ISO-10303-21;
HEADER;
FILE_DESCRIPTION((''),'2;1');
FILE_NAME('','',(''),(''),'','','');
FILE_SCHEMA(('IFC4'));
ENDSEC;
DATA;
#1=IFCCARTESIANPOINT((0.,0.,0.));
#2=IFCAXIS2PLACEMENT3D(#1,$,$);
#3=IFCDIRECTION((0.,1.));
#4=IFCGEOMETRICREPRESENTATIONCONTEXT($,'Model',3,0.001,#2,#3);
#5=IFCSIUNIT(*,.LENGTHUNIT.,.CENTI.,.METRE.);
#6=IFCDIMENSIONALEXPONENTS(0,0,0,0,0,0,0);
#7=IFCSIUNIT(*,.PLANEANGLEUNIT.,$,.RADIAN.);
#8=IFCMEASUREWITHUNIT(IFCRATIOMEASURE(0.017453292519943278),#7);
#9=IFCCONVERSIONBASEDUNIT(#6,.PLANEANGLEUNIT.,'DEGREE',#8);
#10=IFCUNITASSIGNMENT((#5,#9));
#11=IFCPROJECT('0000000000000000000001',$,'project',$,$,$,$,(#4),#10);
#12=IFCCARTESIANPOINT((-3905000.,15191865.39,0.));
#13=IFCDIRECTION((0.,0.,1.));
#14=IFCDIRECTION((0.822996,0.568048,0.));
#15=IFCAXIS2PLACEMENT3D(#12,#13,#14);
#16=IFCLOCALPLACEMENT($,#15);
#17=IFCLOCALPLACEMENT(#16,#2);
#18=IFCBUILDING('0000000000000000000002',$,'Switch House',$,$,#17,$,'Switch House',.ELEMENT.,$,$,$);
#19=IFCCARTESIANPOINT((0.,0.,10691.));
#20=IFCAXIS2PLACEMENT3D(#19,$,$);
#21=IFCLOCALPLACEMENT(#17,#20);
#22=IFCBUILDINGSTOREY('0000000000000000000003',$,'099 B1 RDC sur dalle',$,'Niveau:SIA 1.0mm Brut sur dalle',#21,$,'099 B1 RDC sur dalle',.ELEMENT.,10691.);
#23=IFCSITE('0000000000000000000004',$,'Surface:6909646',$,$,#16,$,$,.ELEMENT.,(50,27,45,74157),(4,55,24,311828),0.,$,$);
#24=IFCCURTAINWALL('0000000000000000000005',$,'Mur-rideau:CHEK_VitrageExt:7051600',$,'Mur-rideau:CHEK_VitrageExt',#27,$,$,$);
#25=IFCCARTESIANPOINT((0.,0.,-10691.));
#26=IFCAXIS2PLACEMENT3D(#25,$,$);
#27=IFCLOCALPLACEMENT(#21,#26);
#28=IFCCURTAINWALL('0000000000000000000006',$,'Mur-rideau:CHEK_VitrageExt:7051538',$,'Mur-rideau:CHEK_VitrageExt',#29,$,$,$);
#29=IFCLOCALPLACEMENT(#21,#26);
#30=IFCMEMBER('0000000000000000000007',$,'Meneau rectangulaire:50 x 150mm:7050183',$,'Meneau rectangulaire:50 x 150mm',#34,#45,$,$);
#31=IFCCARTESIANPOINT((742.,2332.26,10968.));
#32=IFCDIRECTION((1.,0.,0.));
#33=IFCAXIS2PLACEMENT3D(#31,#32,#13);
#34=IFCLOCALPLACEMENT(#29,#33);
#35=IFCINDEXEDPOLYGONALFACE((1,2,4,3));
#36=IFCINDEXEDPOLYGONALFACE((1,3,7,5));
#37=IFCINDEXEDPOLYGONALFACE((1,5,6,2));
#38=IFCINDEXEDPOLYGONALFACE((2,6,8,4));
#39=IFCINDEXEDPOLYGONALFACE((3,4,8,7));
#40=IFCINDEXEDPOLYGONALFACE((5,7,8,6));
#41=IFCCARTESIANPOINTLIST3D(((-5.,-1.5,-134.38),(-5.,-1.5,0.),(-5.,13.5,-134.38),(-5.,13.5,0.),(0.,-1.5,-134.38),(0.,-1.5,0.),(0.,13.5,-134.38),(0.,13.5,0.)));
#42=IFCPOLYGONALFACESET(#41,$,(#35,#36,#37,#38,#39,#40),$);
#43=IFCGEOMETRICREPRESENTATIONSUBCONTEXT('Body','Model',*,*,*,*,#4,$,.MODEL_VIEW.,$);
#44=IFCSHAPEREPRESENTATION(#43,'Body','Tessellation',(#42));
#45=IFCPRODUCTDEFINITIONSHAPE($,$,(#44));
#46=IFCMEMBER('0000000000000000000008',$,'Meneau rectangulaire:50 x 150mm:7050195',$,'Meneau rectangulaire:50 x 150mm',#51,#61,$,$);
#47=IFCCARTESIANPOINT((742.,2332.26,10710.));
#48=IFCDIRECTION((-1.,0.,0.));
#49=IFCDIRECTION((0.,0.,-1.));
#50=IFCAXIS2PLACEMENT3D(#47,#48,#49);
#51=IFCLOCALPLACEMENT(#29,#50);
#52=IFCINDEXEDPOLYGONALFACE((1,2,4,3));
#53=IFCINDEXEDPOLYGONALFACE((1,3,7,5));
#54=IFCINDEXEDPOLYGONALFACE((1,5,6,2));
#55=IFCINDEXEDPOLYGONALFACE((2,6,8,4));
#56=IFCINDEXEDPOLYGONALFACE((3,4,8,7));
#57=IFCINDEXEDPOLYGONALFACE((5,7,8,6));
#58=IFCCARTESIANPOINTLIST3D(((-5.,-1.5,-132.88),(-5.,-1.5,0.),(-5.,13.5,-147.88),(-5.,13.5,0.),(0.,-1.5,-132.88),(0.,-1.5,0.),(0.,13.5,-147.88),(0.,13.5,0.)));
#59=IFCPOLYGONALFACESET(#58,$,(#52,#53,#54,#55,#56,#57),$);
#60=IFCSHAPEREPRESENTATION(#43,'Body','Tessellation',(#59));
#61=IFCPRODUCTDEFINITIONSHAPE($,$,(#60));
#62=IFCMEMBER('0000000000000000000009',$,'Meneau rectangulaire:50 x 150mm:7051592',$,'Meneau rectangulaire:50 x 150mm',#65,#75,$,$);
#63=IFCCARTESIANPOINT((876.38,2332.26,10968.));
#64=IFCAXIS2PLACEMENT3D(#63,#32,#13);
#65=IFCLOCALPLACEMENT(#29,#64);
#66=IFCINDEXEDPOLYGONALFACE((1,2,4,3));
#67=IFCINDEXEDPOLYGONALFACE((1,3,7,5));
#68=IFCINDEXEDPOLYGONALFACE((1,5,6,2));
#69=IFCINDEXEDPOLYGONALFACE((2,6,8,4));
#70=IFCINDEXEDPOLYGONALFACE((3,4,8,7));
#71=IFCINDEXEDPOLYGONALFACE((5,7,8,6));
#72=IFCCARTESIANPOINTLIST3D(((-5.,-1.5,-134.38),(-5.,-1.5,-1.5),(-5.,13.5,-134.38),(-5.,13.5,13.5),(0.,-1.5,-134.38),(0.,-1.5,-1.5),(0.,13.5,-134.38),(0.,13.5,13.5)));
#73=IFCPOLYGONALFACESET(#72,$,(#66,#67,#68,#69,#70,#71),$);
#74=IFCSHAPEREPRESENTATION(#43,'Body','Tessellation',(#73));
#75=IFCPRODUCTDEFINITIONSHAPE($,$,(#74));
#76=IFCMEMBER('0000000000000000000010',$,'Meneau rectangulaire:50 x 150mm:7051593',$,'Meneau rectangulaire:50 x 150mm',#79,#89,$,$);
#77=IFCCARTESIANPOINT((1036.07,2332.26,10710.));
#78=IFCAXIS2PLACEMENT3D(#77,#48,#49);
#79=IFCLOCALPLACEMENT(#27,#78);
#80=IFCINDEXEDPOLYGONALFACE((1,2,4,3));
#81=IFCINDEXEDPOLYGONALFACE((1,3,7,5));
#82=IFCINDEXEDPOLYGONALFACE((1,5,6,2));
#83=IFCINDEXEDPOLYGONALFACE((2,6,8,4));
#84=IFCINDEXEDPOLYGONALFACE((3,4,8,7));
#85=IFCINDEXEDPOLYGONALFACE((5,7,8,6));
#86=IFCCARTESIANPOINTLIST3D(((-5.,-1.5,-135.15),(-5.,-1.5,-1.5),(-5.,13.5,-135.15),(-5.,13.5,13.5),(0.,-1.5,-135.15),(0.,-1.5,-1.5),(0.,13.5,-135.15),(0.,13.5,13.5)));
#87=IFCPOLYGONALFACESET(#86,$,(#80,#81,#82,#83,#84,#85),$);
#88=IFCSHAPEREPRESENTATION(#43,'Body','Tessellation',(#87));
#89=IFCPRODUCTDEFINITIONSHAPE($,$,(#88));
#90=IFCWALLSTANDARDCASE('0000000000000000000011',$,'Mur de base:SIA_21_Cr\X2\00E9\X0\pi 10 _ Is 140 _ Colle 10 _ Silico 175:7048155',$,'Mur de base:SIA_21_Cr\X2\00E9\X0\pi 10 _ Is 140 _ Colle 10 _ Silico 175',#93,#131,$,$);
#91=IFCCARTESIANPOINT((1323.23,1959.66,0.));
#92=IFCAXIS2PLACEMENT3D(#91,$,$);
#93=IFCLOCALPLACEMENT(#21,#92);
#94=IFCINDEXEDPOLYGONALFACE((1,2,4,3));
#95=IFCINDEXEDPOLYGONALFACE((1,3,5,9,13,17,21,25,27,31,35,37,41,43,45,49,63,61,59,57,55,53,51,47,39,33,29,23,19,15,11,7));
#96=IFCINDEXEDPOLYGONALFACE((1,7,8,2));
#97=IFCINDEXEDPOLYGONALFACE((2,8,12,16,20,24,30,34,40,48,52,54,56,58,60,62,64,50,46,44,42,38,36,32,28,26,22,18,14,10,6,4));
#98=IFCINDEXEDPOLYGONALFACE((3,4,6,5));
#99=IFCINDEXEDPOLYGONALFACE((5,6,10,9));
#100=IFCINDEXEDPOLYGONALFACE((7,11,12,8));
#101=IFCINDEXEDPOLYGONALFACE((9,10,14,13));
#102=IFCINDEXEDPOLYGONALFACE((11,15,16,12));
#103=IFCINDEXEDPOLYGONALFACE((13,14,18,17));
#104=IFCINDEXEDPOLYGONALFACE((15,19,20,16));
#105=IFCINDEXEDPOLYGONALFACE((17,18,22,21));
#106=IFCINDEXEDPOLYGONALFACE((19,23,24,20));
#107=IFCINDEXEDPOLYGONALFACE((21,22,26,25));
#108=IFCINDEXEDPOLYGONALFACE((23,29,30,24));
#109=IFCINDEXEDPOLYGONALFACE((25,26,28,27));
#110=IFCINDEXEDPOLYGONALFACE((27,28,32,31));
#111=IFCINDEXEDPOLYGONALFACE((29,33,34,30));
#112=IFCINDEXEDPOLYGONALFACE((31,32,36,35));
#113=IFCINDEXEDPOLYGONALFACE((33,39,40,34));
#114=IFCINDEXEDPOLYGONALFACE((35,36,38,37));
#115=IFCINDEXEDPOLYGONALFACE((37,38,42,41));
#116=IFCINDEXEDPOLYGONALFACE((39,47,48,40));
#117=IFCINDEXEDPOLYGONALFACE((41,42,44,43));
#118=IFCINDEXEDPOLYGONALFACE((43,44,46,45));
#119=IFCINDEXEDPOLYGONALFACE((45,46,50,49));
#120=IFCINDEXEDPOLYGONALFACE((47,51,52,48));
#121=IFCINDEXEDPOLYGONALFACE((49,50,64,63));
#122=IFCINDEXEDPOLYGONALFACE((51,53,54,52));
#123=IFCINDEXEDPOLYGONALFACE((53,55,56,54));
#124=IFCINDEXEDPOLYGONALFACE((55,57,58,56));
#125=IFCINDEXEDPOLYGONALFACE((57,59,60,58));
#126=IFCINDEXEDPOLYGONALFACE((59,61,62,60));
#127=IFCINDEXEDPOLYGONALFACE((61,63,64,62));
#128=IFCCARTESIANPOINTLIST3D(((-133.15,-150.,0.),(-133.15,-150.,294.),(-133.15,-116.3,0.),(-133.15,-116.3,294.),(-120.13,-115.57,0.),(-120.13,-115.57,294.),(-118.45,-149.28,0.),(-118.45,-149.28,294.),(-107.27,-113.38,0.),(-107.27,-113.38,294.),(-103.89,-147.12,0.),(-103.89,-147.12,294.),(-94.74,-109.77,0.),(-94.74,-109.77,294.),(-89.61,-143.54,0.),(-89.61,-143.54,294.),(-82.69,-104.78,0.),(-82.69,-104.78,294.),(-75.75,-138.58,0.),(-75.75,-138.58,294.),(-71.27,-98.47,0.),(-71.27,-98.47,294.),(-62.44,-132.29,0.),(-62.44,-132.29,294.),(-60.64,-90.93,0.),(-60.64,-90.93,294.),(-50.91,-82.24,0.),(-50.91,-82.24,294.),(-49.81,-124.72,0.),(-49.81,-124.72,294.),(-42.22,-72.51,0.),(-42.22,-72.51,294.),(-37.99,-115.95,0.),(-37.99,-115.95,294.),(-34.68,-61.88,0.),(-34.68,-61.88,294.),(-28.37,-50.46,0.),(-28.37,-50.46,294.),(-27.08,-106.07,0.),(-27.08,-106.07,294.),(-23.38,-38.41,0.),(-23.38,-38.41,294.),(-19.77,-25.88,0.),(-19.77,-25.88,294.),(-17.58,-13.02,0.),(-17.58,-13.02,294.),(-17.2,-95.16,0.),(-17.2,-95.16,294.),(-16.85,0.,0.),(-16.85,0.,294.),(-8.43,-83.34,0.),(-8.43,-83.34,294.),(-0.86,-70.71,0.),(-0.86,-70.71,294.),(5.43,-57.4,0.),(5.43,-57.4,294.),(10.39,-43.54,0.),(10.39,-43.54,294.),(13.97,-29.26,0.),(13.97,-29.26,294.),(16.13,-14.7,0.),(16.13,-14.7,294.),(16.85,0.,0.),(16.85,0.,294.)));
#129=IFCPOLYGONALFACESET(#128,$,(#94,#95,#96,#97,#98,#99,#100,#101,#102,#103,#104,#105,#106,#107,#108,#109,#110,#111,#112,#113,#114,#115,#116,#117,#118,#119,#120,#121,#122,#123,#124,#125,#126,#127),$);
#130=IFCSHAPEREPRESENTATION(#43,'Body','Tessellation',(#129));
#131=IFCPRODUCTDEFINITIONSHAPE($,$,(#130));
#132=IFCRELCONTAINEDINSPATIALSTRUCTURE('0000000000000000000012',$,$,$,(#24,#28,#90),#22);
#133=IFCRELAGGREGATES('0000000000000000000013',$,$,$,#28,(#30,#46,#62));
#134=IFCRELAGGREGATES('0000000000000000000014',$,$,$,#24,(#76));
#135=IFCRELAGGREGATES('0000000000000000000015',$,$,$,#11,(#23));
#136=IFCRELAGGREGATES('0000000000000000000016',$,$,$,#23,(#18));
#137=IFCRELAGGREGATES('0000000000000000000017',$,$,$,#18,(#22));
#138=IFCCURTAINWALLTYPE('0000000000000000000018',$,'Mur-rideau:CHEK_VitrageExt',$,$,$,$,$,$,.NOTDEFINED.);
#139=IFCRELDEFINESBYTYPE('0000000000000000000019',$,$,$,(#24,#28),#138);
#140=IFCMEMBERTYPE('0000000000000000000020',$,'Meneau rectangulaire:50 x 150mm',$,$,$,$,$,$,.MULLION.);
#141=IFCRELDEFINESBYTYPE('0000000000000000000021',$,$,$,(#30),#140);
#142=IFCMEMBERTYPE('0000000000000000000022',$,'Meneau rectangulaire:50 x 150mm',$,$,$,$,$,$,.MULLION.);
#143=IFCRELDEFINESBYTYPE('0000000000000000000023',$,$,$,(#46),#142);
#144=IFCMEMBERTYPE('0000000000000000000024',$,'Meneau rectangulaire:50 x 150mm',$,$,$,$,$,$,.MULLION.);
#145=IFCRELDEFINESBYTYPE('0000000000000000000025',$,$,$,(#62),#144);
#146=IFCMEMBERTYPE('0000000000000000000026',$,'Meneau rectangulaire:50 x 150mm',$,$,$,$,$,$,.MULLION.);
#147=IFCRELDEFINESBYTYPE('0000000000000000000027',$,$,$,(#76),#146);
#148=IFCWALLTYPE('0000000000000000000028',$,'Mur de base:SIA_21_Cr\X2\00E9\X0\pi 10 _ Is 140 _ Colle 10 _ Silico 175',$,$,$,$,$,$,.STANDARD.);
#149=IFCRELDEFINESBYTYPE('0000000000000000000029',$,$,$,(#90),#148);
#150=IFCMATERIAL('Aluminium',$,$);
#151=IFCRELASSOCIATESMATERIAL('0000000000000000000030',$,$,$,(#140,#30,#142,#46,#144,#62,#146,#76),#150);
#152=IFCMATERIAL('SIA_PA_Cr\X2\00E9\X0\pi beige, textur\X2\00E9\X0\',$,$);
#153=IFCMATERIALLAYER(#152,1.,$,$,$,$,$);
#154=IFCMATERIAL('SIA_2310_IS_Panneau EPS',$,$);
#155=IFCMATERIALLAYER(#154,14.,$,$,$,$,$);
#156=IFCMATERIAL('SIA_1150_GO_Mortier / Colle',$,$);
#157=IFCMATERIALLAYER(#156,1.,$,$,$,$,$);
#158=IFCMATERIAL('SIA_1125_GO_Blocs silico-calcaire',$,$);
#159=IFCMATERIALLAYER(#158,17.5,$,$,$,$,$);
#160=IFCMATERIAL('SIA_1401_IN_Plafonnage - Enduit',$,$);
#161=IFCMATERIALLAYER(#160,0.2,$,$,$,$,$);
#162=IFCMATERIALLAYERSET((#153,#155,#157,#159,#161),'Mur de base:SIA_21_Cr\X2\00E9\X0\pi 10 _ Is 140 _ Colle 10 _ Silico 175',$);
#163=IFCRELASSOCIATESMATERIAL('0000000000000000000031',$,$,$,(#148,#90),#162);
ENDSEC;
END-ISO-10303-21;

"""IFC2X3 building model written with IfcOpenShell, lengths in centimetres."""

from ifc_helpers import new_model, entity, si_unit, converted_unit, direction, frame, frame_2d, origin, origin_2d_with_axis, place, context, subcontext, project, spatial, polyline, circle_curve, parameter, trimmed, segment, composite_curve, rectangle, outline, extrude, clip, halfspace, source, transform, mapped, material, layer, layer_set, layer_usage, type_object, type_shapes, element, aggregate, save


model = new_model("IFC2X3")

# Units and contexts
model_context = context("Model", 3, precision=0.001, world=origin(), true_north=direction((0.0, 1.0)))
body_context = subcontext(model_context, "Body", "Model", "MODEL_VIEW")
ifc_project = project(units=[si_unit("LENGTHUNIT", "METRE", prefix="CENTI"), converted_unit("PLANEANGLEUNIT", "DEGREE", entity("IfcRatioMeasure", 0.017453292519943278), si_unit("PLANEANGLEUNIT", "RADIAN"), dimensions=[0, 0, 0, 0, 0, 0, 0])], contexts=[model_context])

# Site, building, storey
site_placement = place(None, frame((-3905000.0, 15191865.39, 0.0), z_axis=(0.0, 0.0, 1.0), x_axis=(0.822996, 0.568048, 0.0)))
site = spatial("IfcSite", under=ifc_project, at=site_placement, Name="Surface:6909646", CompositionType="ELEMENT", RefLatitude=(50, 27, 45, 74157), RefLongitude=(4, 55, 24, 311828), RefElevation=0.0)
building_placement = place(site_placement, origin())
building = spatial("IfcBuilding", under=site, at=building_placement, Name="Switch House", LongName="Switch House", CompositionType="ELEMENT")
storey_placement = place(building_placement, frame((0.0, 0.0, 10691.0)))
storey = spatial("IfcBuildingStorey", under=building, at=storey_placement, Name="099 B1 RDC sur dalle", ObjectType="Niveau:SIA 1.0mm Brut sur dalle", LongName="099 B1 RDC sur dalle", CompositionType="ELEMENT", Elevation=10691.0)

# Curtain wall
curtain_wall_type = type_object("IfcCurtainWallType", Name="Mur-rideau:CHEK_VitrageExt", PredefinedType="NOTDEFINED")
ifc_material_1 = material(Name="Aluminium")
curtain_wall_1_placement = place(storey_placement, frame((0.0, 0.0, -10691.0)))
curtain_wall_1 = element("IfcCurtainWall", 1, at=curtain_wall_1_placement, inside=storey, type_object=curtain_wall_type, Name="Mur-rideau:CHEK_VitrageExt:7051600", ObjectType="Mur-rideau:CHEK_VitrageExt")

# Curtain wall
curtain_wall_2_placement = place(storey_placement, frame((0.0, 0.0, -10691.0)))
curtain_wall_2 = element("IfcCurtainWall", 2, at=curtain_wall_2_placement, inside=storey, type_object=curtain_wall_type, Name="Mur-rideau:CHEK_VitrageExt:7051538", ObjectType="Mur-rideau:CHEK_VitrageExt")

# Members
member_type_1 = type_object("IfcMemberType", Name="Meneau rectangulaire:50 x 150mm", PredefinedType="MULLION", material=ifc_material_1)
shared_shape_1 = source(origin(), body_context, "Body", "SweptSolid", [
    extrude(rectangle(XDim=15.0, YDim=5.0, at=origin_2d_with_axis()), frame((-2.5, 6.0, -134.38), z_axis=(0.0, 0.0, 1.0), x_axis=(0.0, -1.0, 0.0)), (0.0, 0.0, 1.0), 134.38),
])
type_shapes(member_type_1, [shared_shape_1])
member_1_placement = place(curtain_wall_2_placement, frame((742.0, 2332.26, 10968.0), z_axis=(1.0, 0.0, 0.0), x_axis=(0.0, 0.0, 1.0)))
member_1 = element("IfcMember", 3, at=member_1_placement, type_object=member_type_1, material=ifc_material_1, Name="Meneau rectangulaire:50 x 150mm:7050183", ObjectType="Meneau rectangulaire:50 x 150mm", context=body_context, shape_type="MappedRepresentation", body=[
    mapped(shared_shape_1, transform((0.0, 0.0, 0.0), scale=1.0)),
])
member_type_2 = type_object("IfcMemberType", Name="Meneau rectangulaire:50 x 150mm", PredefinedType="MULLION", material=ifc_material_1)
shared_shape_2 = source(origin(), body_context, "Body", "SweptSolid", [
    clip(extrude(rectangle(XDim=15.0, YDim=5.0, at=origin_2d_with_axis()), frame((-2.5, 6.0, -147.88), z_axis=(0.0, 0.0, 1.0), x_axis=(0.0, -1.0, 0.0)), (0.0, 0.0, 1.0), 147.88), halfspace(frame((30.48, 0.0, -134.38), z_axis=(0.0, -0.707107, -0.707107), x_axis=(0.0, -0.707107, 0.707107)), False)),
])
type_shapes(member_type_2, [shared_shape_2])
member_2_placement = place(curtain_wall_2_placement, frame((742.0, 2332.26, 10710.0), z_axis=(-1.0, 0.0, 0.0), x_axis=(0.0, 0.0, -1.0)))
member_2 = element("IfcMember", 4, at=member_2_placement, type_object=member_type_2, material=ifc_material_1, Name="Meneau rectangulaire:50 x 150mm:7050195", ObjectType="Meneau rectangulaire:50 x 150mm", context=body_context, shape_type="MappedRepresentation", body=[
    mapped(shared_shape_2, transform((0.0, 0.0, 0.0), scale=1.0)),
])
member_type_3 = type_object("IfcMemberType", Name="Meneau rectangulaire:50 x 150mm", PredefinedType="MULLION", material=ifc_material_1)
shared_shape_3 = source(origin(), body_context, "Body", "SweptSolid", [
    clip(extrude(rectangle(XDim=15.0, YDim=5.0, at=origin_2d_with_axis()), frame((-2.5, 6.0, -134.38), z_axis=(0.0, 0.0, 1.0), x_axis=(0.0, -1.0, 0.0)), (0.0, 0.0, 1.0), 147.88), halfspace(frame((30.48, 0.0, 0.0), z_axis=(0.0, -0.707107, 0.707107), x_axis=(0.0, -0.707107, -0.707107)), False)),
])
type_shapes(member_type_3, [shared_shape_3])
member_3_placement = place(curtain_wall_2_placement, frame((876.38, 2332.26, 10968.0), z_axis=(1.0, 0.0, 0.0), x_axis=(0.0, 0.0, 1.0)))
member_3 = element("IfcMember", 5, at=member_3_placement, type_object=member_type_3, material=ifc_material_1, Name="Meneau rectangulaire:50 x 150mm:7051592", ObjectType="Meneau rectangulaire:50 x 150mm", context=body_context, shape_type="MappedRepresentation", body=[
    mapped(shared_shape_3, transform((0.0, 0.0, 0.0), scale=1.0)),
])
member_type_4 = type_object("IfcMemberType", Name="Meneau rectangulaire:50 x 150mm", PredefinedType="MULLION", material=ifc_material_1)
shared_shape_4 = source(origin(), body_context, "Body", "SweptSolid", [
    clip(extrude(rectangle(XDim=15.0, YDim=5.0, at=origin_2d_with_axis()), frame((-2.5, 6.0, -135.15), z_axis=(0.0, 0.0, 1.0), x_axis=(0.0, -1.0, 0.0)), (0.0, 0.0, 1.0), 148.65), halfspace(frame((30.48, 0.0, 0.0), z_axis=(0.0, -0.707107, 0.707107), x_axis=(0.0, -0.707107, -0.707107)), False)),
])
type_shapes(member_type_4, [shared_shape_4])
member_4_placement = place(curtain_wall_1_placement, frame((1036.07, 2332.26, 10710.0), z_axis=(-1.0, 0.0, 0.0), x_axis=(0.0, 0.0, -1.0)))
member_4 = element("IfcMember", 6, at=member_4_placement, type_object=member_type_4, material=ifc_material_1, Name="Meneau rectangulaire:50 x 150mm:7051593", ObjectType="Meneau rectangulaire:50 x 150mm", context=body_context, shape_type="MappedRepresentation", body=[
    mapped(shared_shape_4, transform((0.0, 0.0, 0.0), scale=1.0)),
])

aggregate(curtain_wall_2, [member_1, member_2, member_3])
aggregate(curtain_wall_1, [member_4])

# Wall
ifc_material_2 = material(Name="SIA_PA_Crépi beige, texturé")
ifc_layer_1 = layer(ifc_material_2, 1.0)
ifc_material_3 = material(Name="SIA_2310_IS_Panneau EPS")
ifc_layer_2 = layer(ifc_material_3, 14.0)
ifc_material_4 = material(Name="SIA_1150_GO_Mortier / Colle")
ifc_layer_3 = layer(ifc_material_4, 1.0)
ifc_material_5 = material(Name="SIA_1125_GO_Blocs silico-calcaire")
ifc_layer_4 = layer(ifc_material_5, 17.5)
ifc_material_6 = material(Name="SIA_1401_IN_Plafonnage - Enduit")
ifc_layer_5 = layer(ifc_material_6, 0.2)
ifc_layer_set_1 = layer_set([ifc_layer_1, ifc_layer_2, ifc_layer_3, ifc_layer_4, ifc_layer_5], Name="Mur de base:SIA_21_Crépi 10 _ Is 140 _ Colle 10 _ Silico 175")
ifc_layer_usage_1 = layer_usage(ifc_layer_set_1, "AXIS2", "POSITIVE", -16.85)
wall_type_1 = type_object("IfcWallType", Name="Mur de base:SIA_21_Crépi 10 _ Is 140 _ Colle 10 _ Silico 175", PredefinedType="STANDARD", material=ifc_layer_set_1)
wall_1_placement = place(storey_placement, frame((1323.23, 1959.66, 0.0)))
element("IfcWallStandardCase", 7, at=wall_1_placement, inside=storey, type_object=wall_type_1, material=ifc_layer_usage_1, Name="Mur de base:SIA_21_Crépi 10 _ Is 140 _ Colle 10 _ Silico 175:7048155", ObjectType="Mur de base:SIA_21_Crépi 10 _ Is 140 _ Colle 10 _ Silico 175", context=body_context, shape_type="Clipping", body=[
    clip(extrude(outline(composite_curve([segment(trimmed(circle_curve(frame_2d((-133.15, 0.0), x_axis=(1.0, 0.0)), 150.0), [parameter(270.0)], [parameter(0.0)], True, "PARAMETER"), True, "CONTINUOUS"), segment(polyline([(16.85, 0.0), (-16.85, 0.0)]), True, "CONTINUOUS"), segment(trimmed(circle_curve(frame_2d((-133.15, 0.0), x_axis=(1.0, 0.0)), 116.3), [parameter(270.0)], [parameter(0.0)], True, "PARAMETER"), False, "CONTINUOUS"), segment(polyline([(-133.15, -116.3), (-133.15, -150.0)]), True, "CONTINUOUS")], self_intersect=False)), origin(), (0.0, 0.0, 1.0), 294.0), halfspace(frame((-133.15, -150.0, 294.0), z_axis=(0.0, 0.0, -1.0), x_axis=(0.0, -1.0, 0.0)), True)),
])

save(model, "model.ifc")
